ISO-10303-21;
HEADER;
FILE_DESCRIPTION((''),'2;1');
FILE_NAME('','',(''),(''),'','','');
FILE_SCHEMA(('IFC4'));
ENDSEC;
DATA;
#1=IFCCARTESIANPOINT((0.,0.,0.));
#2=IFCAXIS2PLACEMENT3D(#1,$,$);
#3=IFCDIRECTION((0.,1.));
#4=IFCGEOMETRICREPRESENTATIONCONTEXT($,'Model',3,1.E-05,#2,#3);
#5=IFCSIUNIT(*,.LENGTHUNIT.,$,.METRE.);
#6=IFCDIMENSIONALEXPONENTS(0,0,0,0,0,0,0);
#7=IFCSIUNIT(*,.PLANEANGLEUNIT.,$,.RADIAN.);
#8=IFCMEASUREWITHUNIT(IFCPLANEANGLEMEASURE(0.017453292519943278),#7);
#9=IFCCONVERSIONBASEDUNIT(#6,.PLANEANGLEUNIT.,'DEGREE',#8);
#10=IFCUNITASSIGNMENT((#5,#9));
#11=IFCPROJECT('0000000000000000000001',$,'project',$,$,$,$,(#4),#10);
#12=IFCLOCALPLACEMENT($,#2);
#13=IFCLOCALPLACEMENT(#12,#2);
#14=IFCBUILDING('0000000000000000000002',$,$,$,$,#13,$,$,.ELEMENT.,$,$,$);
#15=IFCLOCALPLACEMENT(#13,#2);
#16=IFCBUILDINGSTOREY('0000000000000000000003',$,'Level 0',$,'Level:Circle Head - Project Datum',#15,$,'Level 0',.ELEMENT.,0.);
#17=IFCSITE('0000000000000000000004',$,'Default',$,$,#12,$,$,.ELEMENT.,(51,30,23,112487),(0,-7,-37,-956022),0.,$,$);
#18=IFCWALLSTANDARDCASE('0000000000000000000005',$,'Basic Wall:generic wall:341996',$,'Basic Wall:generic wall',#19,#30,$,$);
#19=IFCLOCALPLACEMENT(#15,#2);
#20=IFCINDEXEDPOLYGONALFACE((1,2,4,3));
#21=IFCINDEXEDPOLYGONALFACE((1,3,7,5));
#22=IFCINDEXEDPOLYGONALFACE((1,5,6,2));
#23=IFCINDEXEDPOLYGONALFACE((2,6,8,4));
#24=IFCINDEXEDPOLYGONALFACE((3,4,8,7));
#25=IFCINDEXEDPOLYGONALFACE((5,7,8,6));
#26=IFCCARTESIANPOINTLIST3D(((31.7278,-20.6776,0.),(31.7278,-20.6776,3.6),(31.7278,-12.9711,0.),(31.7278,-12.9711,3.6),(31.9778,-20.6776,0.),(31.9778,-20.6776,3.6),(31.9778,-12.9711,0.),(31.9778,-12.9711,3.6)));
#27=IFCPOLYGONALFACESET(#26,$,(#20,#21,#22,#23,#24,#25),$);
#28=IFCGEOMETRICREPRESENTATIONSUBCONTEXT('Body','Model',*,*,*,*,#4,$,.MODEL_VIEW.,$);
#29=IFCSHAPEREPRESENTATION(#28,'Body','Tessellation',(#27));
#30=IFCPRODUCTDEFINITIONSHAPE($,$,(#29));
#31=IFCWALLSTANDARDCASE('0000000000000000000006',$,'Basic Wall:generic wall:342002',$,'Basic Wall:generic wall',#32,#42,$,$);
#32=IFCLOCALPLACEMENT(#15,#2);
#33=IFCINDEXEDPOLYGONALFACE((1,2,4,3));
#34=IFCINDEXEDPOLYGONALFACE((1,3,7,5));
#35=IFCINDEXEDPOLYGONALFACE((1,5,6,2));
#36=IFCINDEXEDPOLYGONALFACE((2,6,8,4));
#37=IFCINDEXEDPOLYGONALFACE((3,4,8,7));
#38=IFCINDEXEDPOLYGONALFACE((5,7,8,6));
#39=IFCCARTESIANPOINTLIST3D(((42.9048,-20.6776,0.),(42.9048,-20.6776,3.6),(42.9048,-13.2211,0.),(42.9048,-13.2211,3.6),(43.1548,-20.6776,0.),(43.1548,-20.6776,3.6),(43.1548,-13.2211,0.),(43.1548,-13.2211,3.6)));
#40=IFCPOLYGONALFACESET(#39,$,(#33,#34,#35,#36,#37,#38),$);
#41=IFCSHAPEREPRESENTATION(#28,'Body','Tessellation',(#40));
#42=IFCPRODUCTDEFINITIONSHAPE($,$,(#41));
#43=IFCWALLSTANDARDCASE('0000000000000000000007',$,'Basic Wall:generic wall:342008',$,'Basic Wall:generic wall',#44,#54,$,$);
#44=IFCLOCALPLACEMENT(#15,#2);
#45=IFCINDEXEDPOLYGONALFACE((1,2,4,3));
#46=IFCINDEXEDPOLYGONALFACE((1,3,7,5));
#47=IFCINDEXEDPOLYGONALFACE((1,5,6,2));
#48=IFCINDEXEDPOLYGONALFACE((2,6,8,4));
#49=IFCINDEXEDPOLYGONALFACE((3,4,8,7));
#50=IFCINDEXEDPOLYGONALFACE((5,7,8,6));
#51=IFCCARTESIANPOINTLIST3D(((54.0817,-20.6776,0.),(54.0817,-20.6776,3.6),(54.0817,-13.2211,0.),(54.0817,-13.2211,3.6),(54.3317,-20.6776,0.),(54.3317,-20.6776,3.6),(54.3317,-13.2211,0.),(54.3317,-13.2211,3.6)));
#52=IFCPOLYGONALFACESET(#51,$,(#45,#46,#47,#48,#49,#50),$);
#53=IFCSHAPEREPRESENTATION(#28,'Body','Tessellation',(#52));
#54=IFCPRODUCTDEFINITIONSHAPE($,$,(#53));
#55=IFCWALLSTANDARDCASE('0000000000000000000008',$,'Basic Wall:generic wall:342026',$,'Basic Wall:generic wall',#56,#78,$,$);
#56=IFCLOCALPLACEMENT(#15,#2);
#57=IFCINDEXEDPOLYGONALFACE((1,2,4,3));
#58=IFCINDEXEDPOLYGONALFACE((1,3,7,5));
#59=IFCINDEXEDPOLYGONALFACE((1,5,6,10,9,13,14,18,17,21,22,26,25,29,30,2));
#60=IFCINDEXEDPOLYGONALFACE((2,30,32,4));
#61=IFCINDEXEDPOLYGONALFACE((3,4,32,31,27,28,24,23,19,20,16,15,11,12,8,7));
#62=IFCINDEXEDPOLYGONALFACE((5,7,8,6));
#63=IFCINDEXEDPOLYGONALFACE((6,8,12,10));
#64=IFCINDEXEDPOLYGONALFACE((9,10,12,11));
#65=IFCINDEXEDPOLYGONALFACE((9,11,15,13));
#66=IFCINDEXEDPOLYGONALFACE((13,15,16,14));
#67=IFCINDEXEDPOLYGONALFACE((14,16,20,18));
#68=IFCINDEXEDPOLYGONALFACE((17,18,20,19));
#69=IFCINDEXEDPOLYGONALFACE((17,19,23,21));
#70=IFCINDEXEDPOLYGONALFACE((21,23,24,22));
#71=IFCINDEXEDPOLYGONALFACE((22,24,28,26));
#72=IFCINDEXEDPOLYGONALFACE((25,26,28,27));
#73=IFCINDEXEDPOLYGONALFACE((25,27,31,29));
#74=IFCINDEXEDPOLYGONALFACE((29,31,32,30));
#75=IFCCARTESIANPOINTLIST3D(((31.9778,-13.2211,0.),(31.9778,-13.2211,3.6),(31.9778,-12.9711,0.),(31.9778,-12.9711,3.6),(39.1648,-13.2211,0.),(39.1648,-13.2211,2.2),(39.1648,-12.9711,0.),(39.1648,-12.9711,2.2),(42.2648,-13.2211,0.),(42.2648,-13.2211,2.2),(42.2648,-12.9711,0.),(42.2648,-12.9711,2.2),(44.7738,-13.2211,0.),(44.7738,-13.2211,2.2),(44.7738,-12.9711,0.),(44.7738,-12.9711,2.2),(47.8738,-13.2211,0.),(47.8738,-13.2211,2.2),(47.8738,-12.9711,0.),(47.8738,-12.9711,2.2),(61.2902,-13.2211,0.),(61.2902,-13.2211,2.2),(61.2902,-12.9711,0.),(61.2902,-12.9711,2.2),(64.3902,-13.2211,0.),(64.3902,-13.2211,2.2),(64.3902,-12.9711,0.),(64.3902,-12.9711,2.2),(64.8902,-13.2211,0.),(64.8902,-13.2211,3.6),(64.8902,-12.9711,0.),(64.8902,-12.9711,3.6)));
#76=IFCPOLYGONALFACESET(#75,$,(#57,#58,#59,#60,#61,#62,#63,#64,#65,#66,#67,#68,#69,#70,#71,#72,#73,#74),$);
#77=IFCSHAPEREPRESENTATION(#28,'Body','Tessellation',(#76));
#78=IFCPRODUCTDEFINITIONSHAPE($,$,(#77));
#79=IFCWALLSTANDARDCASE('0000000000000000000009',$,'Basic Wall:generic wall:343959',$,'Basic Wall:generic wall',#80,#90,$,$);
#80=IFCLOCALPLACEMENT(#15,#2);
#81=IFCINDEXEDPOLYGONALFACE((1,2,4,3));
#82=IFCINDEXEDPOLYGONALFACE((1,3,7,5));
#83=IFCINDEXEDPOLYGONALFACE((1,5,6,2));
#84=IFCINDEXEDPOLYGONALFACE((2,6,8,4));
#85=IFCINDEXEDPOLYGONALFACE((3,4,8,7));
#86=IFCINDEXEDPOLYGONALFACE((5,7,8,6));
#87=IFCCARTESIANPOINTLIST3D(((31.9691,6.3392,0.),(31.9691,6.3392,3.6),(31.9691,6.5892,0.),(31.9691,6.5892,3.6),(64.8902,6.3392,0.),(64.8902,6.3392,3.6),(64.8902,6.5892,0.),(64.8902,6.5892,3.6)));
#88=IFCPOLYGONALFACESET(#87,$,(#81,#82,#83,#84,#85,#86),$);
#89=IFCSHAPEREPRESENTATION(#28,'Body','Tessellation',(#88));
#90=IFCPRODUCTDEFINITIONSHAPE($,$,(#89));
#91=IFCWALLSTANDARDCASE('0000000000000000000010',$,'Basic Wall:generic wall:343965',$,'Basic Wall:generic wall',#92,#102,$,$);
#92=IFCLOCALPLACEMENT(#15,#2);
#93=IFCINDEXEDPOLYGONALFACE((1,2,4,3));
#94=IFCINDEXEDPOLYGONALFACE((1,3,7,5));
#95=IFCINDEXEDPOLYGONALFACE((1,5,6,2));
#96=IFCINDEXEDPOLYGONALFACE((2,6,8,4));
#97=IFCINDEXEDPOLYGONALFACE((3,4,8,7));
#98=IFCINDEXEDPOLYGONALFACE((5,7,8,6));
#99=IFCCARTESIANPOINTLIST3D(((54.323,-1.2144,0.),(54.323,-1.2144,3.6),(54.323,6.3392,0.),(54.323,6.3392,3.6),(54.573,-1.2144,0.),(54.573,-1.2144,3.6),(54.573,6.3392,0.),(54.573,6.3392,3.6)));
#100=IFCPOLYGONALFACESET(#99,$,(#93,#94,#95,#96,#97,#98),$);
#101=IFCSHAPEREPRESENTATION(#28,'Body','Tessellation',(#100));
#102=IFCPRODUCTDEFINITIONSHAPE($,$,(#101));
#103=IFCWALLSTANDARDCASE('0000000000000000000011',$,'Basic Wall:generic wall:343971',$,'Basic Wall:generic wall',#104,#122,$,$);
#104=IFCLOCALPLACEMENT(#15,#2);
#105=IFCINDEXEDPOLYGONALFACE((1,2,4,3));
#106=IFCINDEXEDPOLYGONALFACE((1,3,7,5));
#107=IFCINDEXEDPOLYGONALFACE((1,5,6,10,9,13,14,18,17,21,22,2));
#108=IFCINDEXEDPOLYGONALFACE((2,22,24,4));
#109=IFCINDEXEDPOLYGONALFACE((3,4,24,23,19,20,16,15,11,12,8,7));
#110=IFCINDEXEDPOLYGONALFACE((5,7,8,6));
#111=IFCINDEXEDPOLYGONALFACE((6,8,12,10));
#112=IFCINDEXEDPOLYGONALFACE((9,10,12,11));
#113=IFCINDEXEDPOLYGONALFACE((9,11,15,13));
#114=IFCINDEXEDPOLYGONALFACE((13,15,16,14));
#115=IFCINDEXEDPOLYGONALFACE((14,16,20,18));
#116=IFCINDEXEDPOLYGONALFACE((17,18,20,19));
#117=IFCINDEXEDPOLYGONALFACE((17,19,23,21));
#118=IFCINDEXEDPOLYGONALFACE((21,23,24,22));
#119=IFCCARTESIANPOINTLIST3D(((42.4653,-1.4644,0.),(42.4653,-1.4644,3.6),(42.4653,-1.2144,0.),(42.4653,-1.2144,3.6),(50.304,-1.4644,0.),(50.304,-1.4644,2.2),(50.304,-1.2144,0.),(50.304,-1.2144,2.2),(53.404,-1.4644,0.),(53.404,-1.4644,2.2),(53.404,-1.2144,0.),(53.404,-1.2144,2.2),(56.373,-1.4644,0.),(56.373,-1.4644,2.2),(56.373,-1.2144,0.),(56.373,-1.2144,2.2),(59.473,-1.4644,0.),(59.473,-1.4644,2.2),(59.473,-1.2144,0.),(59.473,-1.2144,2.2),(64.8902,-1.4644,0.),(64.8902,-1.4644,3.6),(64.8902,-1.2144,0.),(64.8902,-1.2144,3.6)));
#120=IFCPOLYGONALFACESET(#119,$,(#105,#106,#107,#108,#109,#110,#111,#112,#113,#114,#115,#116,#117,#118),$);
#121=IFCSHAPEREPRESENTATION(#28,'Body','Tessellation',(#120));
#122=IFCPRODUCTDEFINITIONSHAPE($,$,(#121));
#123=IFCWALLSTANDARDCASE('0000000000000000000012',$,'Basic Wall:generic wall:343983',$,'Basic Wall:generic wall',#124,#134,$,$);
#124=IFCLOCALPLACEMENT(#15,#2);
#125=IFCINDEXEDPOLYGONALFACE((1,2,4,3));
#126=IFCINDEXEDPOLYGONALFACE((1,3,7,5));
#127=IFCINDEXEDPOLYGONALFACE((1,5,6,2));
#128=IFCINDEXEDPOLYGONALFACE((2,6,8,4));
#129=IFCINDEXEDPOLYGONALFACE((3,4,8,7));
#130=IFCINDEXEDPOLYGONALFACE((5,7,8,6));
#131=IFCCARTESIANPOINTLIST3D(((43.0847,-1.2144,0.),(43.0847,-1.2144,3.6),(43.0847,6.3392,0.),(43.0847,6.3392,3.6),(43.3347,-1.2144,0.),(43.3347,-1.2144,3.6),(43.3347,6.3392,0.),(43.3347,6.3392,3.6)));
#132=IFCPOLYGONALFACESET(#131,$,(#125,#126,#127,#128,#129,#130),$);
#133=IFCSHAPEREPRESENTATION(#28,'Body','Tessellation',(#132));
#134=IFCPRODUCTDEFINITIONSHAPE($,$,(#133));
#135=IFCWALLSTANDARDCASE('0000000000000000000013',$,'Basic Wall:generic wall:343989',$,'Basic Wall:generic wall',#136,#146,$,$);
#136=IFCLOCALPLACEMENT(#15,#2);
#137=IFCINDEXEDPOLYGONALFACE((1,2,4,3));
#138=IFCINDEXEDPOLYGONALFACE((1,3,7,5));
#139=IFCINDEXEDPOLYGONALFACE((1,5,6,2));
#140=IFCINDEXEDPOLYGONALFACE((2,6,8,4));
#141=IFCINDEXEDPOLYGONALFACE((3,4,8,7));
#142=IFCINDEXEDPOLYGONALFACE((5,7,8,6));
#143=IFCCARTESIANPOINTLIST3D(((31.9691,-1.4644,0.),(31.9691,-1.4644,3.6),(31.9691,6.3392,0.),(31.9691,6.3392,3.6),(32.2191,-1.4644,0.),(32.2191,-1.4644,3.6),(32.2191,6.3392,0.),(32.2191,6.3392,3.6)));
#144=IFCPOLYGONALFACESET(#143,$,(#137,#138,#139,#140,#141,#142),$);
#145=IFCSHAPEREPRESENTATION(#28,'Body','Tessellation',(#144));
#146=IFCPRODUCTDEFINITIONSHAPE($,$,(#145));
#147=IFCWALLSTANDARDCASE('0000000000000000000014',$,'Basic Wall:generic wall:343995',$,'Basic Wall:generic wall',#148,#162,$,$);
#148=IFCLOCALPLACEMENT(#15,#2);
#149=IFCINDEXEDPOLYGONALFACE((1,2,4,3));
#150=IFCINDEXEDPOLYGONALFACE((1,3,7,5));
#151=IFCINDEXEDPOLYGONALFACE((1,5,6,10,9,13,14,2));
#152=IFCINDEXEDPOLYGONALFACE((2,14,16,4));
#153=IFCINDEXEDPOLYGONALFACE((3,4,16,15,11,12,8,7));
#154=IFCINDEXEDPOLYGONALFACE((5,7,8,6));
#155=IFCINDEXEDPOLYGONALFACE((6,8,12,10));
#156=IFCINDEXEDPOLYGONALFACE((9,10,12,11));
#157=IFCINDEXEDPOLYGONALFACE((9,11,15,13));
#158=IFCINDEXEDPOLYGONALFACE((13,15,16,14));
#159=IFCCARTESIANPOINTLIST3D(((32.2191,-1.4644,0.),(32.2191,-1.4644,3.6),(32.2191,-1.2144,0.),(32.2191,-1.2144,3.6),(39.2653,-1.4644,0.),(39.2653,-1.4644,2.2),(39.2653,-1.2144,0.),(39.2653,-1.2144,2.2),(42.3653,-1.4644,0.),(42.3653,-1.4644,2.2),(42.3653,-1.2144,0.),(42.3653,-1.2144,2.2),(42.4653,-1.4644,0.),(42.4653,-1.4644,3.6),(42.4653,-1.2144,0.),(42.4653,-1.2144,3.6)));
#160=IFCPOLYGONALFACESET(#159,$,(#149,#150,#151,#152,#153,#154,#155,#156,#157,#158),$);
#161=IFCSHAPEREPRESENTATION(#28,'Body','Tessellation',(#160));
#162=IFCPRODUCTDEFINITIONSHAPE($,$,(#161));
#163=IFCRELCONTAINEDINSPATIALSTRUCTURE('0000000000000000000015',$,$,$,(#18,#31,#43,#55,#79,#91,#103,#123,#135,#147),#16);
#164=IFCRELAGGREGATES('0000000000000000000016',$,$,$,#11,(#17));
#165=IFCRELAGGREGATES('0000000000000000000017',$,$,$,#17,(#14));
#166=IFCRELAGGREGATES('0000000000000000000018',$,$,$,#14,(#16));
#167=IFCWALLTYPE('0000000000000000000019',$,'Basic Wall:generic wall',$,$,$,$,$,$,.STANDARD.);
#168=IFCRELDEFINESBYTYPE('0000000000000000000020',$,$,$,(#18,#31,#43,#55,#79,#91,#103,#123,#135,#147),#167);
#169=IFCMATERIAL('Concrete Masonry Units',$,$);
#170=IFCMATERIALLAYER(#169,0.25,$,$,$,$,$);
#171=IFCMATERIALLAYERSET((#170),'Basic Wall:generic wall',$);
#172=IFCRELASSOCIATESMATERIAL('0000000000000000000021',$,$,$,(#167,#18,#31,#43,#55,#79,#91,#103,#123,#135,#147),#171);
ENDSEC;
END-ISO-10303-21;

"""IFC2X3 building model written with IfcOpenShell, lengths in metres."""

from ifc_helpers import new_model, entity, si_unit, converted_unit, direction, frame, frame_2d, origin, place, context, subcontext, project, spatial, rectangle, extrude, material, layer, layer_set, layer_usage, type_object, element, save


model = new_model("IFC2X3")

# Units and contexts
model_context = context("Model", 3, precision=1e-05, world=origin(), true_north=direction((0.0, 1.0)))
body_context = subcontext(model_context, "Body", "Model", "MODEL_VIEW")
ifc_project = project(units=[si_unit("LENGTHUNIT", "METRE"), converted_unit("PLANEANGLEUNIT", "DEGREE", entity("IfcPlaneAngleMeasure", 0.017453292519943278), si_unit("PLANEANGLEUNIT", "RADIAN"), dimensions=[0, 0, 0, 0, 0, 0, 0])], contexts=[model_context])

# Site, building, storey
site_placement = place(None, origin())
site = spatial("IfcSite", under=ifc_project, at=site_placement, Name="Default", CompositionType="ELEMENT", RefLatitude=(51, 30, 23, 112487), RefLongitude=(0, -7, -37, -956022), RefElevation=0.0)
building_placement = place(site_placement, origin())
building = spatial("IfcBuilding", under=site, at=building_placement, CompositionType="ELEMENT")
storey_placement = place(building_placement, origin())
storey = spatial("IfcBuildingStorey", under=building, at=storey_placement, Name="Level 0", ObjectType="Level:Circle Head - Project Datum", LongName="Level 0", CompositionType="ELEMENT", Elevation=0.0)

# Walls
ifc_material = material(Name="Concrete Masonry Units")
ifc_layer = layer(ifc_material, 0.25)
ifc_layer_set = layer_set([ifc_layer], Name="Basic Wall:generic wall")
ifc_layer_usage_1 = layer_usage(ifc_layer_set, "AXIS2", "NEGATIVE", 0.125)
wall_type = type_object("IfcWallType", Name="Basic Wall:generic wall", PredefinedType="STANDARD", material=ifc_layer_set)
wall_1_placement = place(storey_placement, frame((31.8528, -20.6776, 0.0), z_axis=(0.0, 0.0, 1.0), x_axis=(0.0, 1.0, 0.0)))
element("IfcWallStandardCase", 1, at=wall_1_placement, inside=storey, type_object=wall_type, material=ifc_layer_usage_1, Name="Basic Wall:generic wall:341996", ObjectType="Basic Wall:generic wall", context=body_context, shape_type="SweptSolid", body=[
    extrude(rectangle(XDim=7.7065, YDim=0.25, at=frame_2d((3.8532, 0.0), x_axis=(-1.0, 0.0))), origin(), (0.0, 0.0, 1.0), 3.6),
])
ifc_layer_usage_2 = layer_usage(ifc_layer_set, "AXIS2", "NEGATIVE", 0.125)
wall_2_placement = place(storey_placement, frame((43.0298, -20.6776, 0.0), z_axis=(0.0, 0.0, 1.0), x_axis=(0.0, 1.0, 0.0)))
element("IfcWallStandardCase", 2, at=wall_2_placement, inside=storey, type_object=wall_type, material=ifc_layer_usage_2, Name="Basic Wall:generic wall:342002", ObjectType="Basic Wall:generic wall", context=body_context, shape_type="SweptSolid", body=[
    extrude(rectangle(XDim=7.4565, YDim=0.25, at=frame_2d((3.7282, 0.0), x_axis=(-1.0, 0.0))), origin(), (0.0, 0.0, 1.0), 3.6),
])
ifc_layer_usage_3 = layer_usage(ifc_layer_set, "AXIS2", "NEGATIVE", 0.125)
wall_3_placement = place(storey_placement, frame((54.2067, -20.6776, 0.0), z_axis=(0.0, 0.0, 1.0), x_axis=(0.0, 1.0, 0.0)))
element("IfcWallStandardCase", 3, at=wall_3_placement, inside=storey, type_object=wall_type, material=ifc_layer_usage_3, Name="Basic Wall:generic wall:342008", ObjectType="Basic Wall:generic wall", context=body_context, shape_type="SweptSolid", body=[
    extrude(rectangle(XDim=7.4565, YDim=0.25, at=frame_2d((3.7282, 0.0), x_axis=(-1.0, 0.0))), origin(), (0.0, 0.0, 1.0), 3.6),
])

# Wall, openings
ifc_layer_usage_4 = layer_usage(ifc_layer_set, "AXIS2", "NEGATIVE", 0.125)
wall_4_placement = place(storey_placement, frame((64.8902, -13.0961, 0.0), z_axis=(0.0, 0.0, 1.0), x_axis=(-1.0, 0.0, 0.0)))
wall_4 = element("IfcWallStandardCase", 4, at=wall_4_placement, inside=storey, type_object=wall_type, material=ifc_layer_usage_4, Name="Basic Wall:generic wall:342026", ObjectType="Basic Wall:generic wall", context=body_context, shape_type="SweptSolid", body=[
    extrude(rectangle(XDim=32.9123, YDim=0.25, at=frame_2d((16.4562, 0.0), x_axis=(-1.0, 0.0))), origin(), (0.0, 0.0, 1.0), 3.6),
])
opening_1_placement = place(wall_4_placement, frame((0.5, -0.125, 0.0)))
element("IfcOpeningElement", 5, at=opening_1_placement, cuts=wall_4, ObjectType="Opening", context=body_context, shape_type="SweptSolid", body=[
    extrude(rectangle(XDim=2.2, YDim=3.1, at=frame_2d((1.1, 1.55), x_axis=(1.0, 0.0))), frame((0.0, 0.0, 0.0), z_axis=(0.0, 1.0, 0.0), x_axis=(0.0, 0.0, 1.0)), (0.0, 0.0, 1.0), 0.25),
])
opening_2_placement = place(wall_4_placement, frame((17.0164, -0.125, 0.0)))
element("IfcOpeningElement", 6, at=opening_2_placement, cuts=wall_4, ObjectType="Opening", context=body_context, shape_type="SweptSolid", body=[
    extrude(rectangle(XDim=2.2, YDim=3.1, at=frame_2d((1.1, 1.55), x_axis=(1.0, 0.0))), frame((0.0, 0.0, 0.0), z_axis=(0.0, 1.0, 0.0), x_axis=(0.0, 0.0, 1.0)), (0.0, 0.0, 1.0), 0.25),
])
opening_3_placement = place(wall_4_placement, frame((22.6254, -0.125, 0.0)))
element("IfcOpeningElement", 7, at=opening_3_placement, cuts=wall_4, ObjectType="Opening", context=body_context, shape_type="SweptSolid", body=[
    extrude(rectangle(XDim=2.2, YDim=3.1, at=frame_2d((1.1, 1.55), x_axis=(1.0, 0.0))), frame((0.0, 0.0, 0.0), z_axis=(0.0, 1.0, 0.0), x_axis=(0.0, 0.0, 1.0)), (0.0, 0.0, 1.0), 0.25),
])

# Walls
ifc_layer_usage_5 = layer_usage(ifc_layer_set, "AXIS2", "NEGATIVE", 0.125)
wall_5_placement = place(storey_placement, frame((64.8902, 6.4642, 0.0), z_axis=(0.0, 0.0, 1.0), x_axis=(-1.0, 0.0, 0.0)))
element("IfcWallStandardCase", 8, at=wall_5_placement, inside=storey, type_object=wall_type, material=ifc_layer_usage_5, Name="Basic Wall:generic wall:343959", ObjectType="Basic Wall:generic wall", context=body_context, shape_type="SweptSolid", body=[
    extrude(rectangle(XDim=32.921, YDim=0.25, at=frame_2d((16.4605, 0.0), x_axis=(-1.0, 0.0))), origin(), (0.0, 0.0, 1.0), 3.6),
])
ifc_layer_usage_6 = layer_usage(ifc_layer_set, "AXIS2", "NEGATIVE", 0.125)
wall_6_placement = place(storey_placement, frame((54.448, 6.3392, 0.0), z_axis=(0.0, 0.0, 1.0), x_axis=(0.0, -1.0, 0.0)))
element("IfcWallStandardCase", 9, at=wall_6_placement, inside=storey, type_object=wall_type, material=ifc_layer_usage_6, Name="Basic Wall:generic wall:343965", ObjectType="Basic Wall:generic wall", context=body_context, shape_type="SweptSolid", body=[
    extrude(rectangle(XDim=7.5536, YDim=0.25, at=frame_2d((3.7768, 0.0), x_axis=(-1.0, 0.0))), origin(), (0.0, 0.0, 1.0), 3.6),
])

# Wall, openings
ifc_layer_usage_7 = layer_usage(ifc_layer_set, "AXIS2", "NEGATIVE", 0.125)
wall_7_placement = place(storey_placement, frame((42.4653, -1.3394, 0.0)))
wall_7 = element("IfcWallStandardCase", 10, at=wall_7_placement, inside=storey, type_object=wall_type, material=ifc_layer_usage_7, Name="Basic Wall:generic wall:343971", ObjectType="Basic Wall:generic wall", context=body_context, shape_type="SweptSolid", body=[
    extrude(rectangle(XDim=22.4249, YDim=0.25, at=frame_2d((11.2124, 0.0), x_axis=(1.0, 0.0))), origin(), (0.0, 0.0, 1.0), 3.6),
])
opening_4_placement = place(wall_7_placement, frame((7.8387, -0.125, 0.0)))
element("IfcOpeningElement", 11, at=opening_4_placement, cuts=wall_7, ObjectType="Opening", context=body_context, shape_type="SweptSolid", body=[
    extrude(rectangle(XDim=2.2, YDim=3.1, at=frame_2d((1.1, 1.55), x_axis=(1.0, 0.0))), frame((0.0, 0.0, 0.0), z_axis=(0.0, 1.0, 0.0), x_axis=(0.0, 0.0, 1.0)), (0.0, 0.0, 1.0), 0.25),
])
opening_5_placement = place(wall_7_placement, frame((13.9077, -0.125, 0.0)))
element("IfcOpeningElement", 12, at=opening_5_placement, cuts=wall_7, ObjectType="Opening", context=body_context, shape_type="SweptSolid", body=[
    extrude(rectangle(XDim=2.2, YDim=3.1, at=frame_2d((1.1, 1.55), x_axis=(1.0, 0.0))), frame((0.0, 0.0, 0.0), z_axis=(0.0, 1.0, 0.0), x_axis=(0.0, 0.0, 1.0)), (0.0, 0.0, 1.0), 0.25),
])

# Walls
ifc_layer_usage_8 = layer_usage(ifc_layer_set, "AXIS2", "NEGATIVE", 0.125)
wall_8_placement = place(storey_placement, frame((43.2097, 6.3392, 0.0), z_axis=(0.0, 0.0, 1.0), x_axis=(0.0, -1.0, 0.0)))
element("IfcWallStandardCase", 13, at=wall_8_placement, inside=storey, type_object=wall_type, material=ifc_layer_usage_8, Name="Basic Wall:generic wall:343983", ObjectType="Basic Wall:generic wall", context=body_context, shape_type="SweptSolid", body=[
    extrude(rectangle(XDim=7.5536, YDim=0.25, at=frame_2d((3.7768, 0.0), x_axis=(-1.0, 0.0))), origin(), (0.0, 0.0, 1.0), 3.6),
])
ifc_layer_usage_9 = layer_usage(ifc_layer_set, "AXIS2", "NEGATIVE", 0.125)
wall_9_placement = place(storey_placement, frame((32.0941, 6.3392, 0.0), z_axis=(0.0, 0.0, 1.0), x_axis=(0.0, -1.0, 0.0)))
element("IfcWallStandardCase", 14, at=wall_9_placement, inside=storey, type_object=wall_type, material=ifc_layer_usage_9, Name="Basic Wall:generic wall:343989", ObjectType="Basic Wall:generic wall", context=body_context, shape_type="SweptSolid", body=[
    extrude(rectangle(XDim=7.8036, YDim=0.25, at=frame_2d((3.9018, 0.0), x_axis=(-1.0, 0.0))), origin(), (0.0, 0.0, 1.0), 3.6),
])

# Wall, opening
ifc_layer_usage_10 = layer_usage(ifc_layer_set, "AXIS2", "NEGATIVE", 0.125)
wall_10_placement = place(storey_placement, frame((32.2191, -1.3394, 0.0)))
wall_10 = element("IfcWallStandardCase", 15, at=wall_10_placement, inside=storey, type_object=wall_type, material=ifc_layer_usage_10, Name="Basic Wall:generic wall:343995", ObjectType="Basic Wall:generic wall", context=body_context, shape_type="SweptSolid", body=[
    extrude(rectangle(XDim=10.2462, YDim=0.25, at=frame_2d((5.1231, 0.0), x_axis=(1.0, 0.0))), origin(), (0.0, 0.0, 1.0), 3.6),
])
opening_6_placement = place(wall_10_placement, frame((7.0462, -0.125, 0.0)))
element("IfcOpeningElement", 16, at=opening_6_placement, cuts=wall_10, ObjectType="Opening", context=body_context, shape_type="SweptSolid", body=[
    extrude(rectangle(XDim=2.2, YDim=3.1, at=frame_2d((1.1, 1.55), x_axis=(1.0, 0.0))), frame((0.0, 0.0, 0.0), z_axis=(0.0, 1.0, 0.0), x_axis=(0.0, 0.0, 1.0)), (0.0, 0.0, 1.0), 0.25),
])

save(model, "model.ifc")
